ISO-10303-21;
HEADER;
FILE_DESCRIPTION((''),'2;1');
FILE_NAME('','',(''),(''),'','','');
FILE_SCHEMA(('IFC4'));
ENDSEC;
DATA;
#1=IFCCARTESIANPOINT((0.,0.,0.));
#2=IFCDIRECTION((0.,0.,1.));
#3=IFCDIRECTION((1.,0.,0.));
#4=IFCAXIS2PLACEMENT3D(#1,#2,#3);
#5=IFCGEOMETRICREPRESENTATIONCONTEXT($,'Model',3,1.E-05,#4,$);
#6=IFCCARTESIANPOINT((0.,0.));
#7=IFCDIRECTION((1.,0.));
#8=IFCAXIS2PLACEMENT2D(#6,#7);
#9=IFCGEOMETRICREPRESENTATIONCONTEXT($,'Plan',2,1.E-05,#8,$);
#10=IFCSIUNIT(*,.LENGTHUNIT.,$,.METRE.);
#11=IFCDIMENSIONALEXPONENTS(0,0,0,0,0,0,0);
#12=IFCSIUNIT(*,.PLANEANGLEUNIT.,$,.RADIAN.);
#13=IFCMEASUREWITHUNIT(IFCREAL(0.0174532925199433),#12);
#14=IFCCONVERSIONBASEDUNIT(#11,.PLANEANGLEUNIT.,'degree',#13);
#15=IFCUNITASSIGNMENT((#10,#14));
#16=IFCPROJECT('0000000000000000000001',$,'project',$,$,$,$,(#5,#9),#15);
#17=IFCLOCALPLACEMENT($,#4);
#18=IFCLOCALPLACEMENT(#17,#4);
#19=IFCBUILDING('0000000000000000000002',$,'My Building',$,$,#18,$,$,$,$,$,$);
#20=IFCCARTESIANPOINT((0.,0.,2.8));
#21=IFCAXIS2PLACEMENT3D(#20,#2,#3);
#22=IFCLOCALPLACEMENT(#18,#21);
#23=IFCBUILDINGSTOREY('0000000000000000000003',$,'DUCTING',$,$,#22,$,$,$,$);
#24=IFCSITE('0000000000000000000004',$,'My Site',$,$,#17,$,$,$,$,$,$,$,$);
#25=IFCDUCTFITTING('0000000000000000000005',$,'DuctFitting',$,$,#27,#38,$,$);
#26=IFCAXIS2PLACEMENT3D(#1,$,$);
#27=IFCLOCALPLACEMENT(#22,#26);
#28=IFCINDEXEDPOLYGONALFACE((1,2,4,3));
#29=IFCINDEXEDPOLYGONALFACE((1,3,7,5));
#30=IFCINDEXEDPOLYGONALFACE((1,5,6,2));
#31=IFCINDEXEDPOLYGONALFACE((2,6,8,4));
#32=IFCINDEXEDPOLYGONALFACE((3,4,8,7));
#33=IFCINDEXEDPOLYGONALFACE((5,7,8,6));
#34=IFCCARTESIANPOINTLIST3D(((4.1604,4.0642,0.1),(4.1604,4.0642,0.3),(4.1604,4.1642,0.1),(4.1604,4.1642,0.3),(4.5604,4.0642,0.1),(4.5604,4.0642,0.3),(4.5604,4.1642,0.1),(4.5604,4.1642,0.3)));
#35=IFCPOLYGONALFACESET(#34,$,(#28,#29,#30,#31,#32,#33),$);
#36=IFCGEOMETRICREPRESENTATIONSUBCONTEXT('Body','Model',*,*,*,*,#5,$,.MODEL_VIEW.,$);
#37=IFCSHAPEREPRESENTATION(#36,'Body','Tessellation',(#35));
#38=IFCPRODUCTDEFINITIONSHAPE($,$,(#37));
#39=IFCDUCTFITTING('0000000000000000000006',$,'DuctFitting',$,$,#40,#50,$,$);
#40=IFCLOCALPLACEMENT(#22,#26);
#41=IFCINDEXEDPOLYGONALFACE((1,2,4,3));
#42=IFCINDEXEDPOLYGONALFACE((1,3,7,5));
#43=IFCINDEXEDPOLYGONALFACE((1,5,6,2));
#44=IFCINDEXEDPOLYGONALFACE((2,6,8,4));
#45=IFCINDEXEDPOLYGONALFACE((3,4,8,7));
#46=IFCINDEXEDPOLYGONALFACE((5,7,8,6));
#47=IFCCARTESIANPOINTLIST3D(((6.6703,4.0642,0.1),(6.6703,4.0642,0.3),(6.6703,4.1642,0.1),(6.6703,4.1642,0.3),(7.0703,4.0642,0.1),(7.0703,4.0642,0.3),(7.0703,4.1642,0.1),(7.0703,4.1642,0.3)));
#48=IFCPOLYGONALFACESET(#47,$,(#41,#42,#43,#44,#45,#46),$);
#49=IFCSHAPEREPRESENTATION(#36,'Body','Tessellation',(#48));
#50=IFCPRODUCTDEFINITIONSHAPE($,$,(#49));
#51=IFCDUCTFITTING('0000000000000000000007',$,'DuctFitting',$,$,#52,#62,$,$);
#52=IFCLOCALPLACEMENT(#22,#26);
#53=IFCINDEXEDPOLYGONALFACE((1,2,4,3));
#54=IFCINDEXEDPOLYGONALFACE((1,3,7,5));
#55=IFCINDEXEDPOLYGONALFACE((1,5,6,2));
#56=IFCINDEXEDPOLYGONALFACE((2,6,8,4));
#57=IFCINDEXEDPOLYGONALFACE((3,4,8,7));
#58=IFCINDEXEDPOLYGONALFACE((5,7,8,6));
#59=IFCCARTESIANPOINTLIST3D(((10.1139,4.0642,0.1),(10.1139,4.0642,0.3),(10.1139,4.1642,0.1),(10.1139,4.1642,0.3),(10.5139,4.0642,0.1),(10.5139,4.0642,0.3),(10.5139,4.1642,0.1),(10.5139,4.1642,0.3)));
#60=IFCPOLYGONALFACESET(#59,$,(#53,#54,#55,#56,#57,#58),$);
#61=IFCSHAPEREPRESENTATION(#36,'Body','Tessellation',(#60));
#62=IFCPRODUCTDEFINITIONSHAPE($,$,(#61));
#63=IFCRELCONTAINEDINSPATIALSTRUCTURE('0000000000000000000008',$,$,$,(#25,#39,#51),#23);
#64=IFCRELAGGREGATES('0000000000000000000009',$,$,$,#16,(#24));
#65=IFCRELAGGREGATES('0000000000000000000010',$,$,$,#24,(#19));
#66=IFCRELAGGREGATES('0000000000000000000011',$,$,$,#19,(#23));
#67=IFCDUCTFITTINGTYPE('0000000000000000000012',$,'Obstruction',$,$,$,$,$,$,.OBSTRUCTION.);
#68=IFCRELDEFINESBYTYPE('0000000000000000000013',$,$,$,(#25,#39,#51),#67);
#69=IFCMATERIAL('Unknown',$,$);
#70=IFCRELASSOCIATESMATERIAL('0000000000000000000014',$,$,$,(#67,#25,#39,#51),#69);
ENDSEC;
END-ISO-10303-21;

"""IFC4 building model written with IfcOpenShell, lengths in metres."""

from ifc_helpers import new_model, entity, si_unit, converted_unit, frame, origin_with_axes, origin_2d_with_axis, place, context, subcontext, project, spatial, rectangle, extrude, material, material_profile, profile_set, profile_usage, type_object, element, save


model = new_model("IFC4")

# Units and contexts
model_context = context("Model", 3, precision=1e-05, world=origin_with_axes())
plan_context = context("Plan", 2, precision=1e-05, world=origin_2d_with_axis())
body_context = subcontext(model_context, "Body", "Model", "MODEL_VIEW")
ifc_project = project(units=[si_unit("LENGTHUNIT", "METRE"), converted_unit("PLANEANGLEUNIT", "degree", entity("IfcReal", 0.0174532925199433), si_unit("PLANEANGLEUNIT", "RADIAN"), dimensions=[0, 0, 0, 0, 0, 0, 0])], contexts=[model_context, plan_context])

# Site, building, storey
site_placement = place(None, origin_with_axes())
site = spatial("IfcSite", under=ifc_project, at=site_placement, Name="My Site")
building_placement = place(site_placement, origin_with_axes())
building = spatial("IfcBuilding", under=site, at=building_placement, Name="My Building")
storey_placement = place(building_placement, frame((0.0, 0.0, 2.8), z_axis=(0.0, 0.0, 1.0), x_axis=(1.0, 0.0, 0.0)))
storey = spatial("IfcBuildingStorey", under=building, at=storey_placement, Name="DUCTING")

# Shared definitions
ifc_material = material(Name="Unknown")

# Duct fittings
ifc_material_profile_1 = material_profile(ifc_material, rectangle(XDim=0.4, YDim=0.2))
ifc_profile_set_1 = profile_set([ifc_material_profile_1])
duct_fitting_type_1 = type_object("IfcDuctFittingType", Name="Obstruction", PredefinedType="OBSTRUCTION", material=ifc_profile_set_1)
ifc_profile_usage_1 = profile_usage(ifc_profile_set_1, cardinal=5)
duct_fitting_1_placement = place(storey_placement, frame((4.3604, 4.1642, 0.2), z_axis=(0.0, -1.0, 0.0), x_axis=(1.0, 0.0, 0.0)))
element("IfcDuctFitting", 1, at=duct_fitting_1_placement, inside=storey, type_object=duct_fitting_type_1, material=ifc_profile_usage_1, Name="DuctFitting", context=body_context, shape_type="SweptSolid", body=[
    extrude(rectangle(XDim=0.4, YDim=0.2), origin_with_axes(), (0.0, 0.0, 1.0), 0.1),
])
ifc_profile_usage_2 = profile_usage(ifc_profile_set_1, cardinal=5)
duct_fitting_2_placement = place(storey_placement, frame((6.8703, 4.1642, 0.2), z_axis=(0.0, -1.0, 0.0), x_axis=(1.0, 0.0, 0.0)))
element("IfcDuctFitting", 2, at=duct_fitting_2_placement, inside=storey, type_object=duct_fitting_type_1, material=ifc_profile_usage_2, Name="DuctFitting", context=body_context, shape_type="SweptSolid", body=[
    extrude(rectangle(XDim=0.4, YDim=0.2), origin_with_axes(), (0.0, 0.0, 1.0), 0.1),
])
ifc_profile_usage_3 = profile_usage(ifc_profile_set_1, cardinal=5)
duct_fitting_3_placement = place(storey_placement, frame((10.3139, 4.1642, 0.2), z_axis=(0.0, -1.0, 0.0), x_axis=(1.0, 0.0, 0.0)))
element("IfcDuctFitting", 3, at=duct_fitting_3_placement, inside=storey, type_object=duct_fitting_type_1, material=ifc_profile_usage_3, Name="DuctFitting", context=body_context, shape_type="SweptSolid", body=[
    extrude(rectangle(XDim=0.4, YDim=0.2), origin_with_axes(), (0.0, 0.0, 1.0), 0.1),
])

save(model, "model.ifc")
